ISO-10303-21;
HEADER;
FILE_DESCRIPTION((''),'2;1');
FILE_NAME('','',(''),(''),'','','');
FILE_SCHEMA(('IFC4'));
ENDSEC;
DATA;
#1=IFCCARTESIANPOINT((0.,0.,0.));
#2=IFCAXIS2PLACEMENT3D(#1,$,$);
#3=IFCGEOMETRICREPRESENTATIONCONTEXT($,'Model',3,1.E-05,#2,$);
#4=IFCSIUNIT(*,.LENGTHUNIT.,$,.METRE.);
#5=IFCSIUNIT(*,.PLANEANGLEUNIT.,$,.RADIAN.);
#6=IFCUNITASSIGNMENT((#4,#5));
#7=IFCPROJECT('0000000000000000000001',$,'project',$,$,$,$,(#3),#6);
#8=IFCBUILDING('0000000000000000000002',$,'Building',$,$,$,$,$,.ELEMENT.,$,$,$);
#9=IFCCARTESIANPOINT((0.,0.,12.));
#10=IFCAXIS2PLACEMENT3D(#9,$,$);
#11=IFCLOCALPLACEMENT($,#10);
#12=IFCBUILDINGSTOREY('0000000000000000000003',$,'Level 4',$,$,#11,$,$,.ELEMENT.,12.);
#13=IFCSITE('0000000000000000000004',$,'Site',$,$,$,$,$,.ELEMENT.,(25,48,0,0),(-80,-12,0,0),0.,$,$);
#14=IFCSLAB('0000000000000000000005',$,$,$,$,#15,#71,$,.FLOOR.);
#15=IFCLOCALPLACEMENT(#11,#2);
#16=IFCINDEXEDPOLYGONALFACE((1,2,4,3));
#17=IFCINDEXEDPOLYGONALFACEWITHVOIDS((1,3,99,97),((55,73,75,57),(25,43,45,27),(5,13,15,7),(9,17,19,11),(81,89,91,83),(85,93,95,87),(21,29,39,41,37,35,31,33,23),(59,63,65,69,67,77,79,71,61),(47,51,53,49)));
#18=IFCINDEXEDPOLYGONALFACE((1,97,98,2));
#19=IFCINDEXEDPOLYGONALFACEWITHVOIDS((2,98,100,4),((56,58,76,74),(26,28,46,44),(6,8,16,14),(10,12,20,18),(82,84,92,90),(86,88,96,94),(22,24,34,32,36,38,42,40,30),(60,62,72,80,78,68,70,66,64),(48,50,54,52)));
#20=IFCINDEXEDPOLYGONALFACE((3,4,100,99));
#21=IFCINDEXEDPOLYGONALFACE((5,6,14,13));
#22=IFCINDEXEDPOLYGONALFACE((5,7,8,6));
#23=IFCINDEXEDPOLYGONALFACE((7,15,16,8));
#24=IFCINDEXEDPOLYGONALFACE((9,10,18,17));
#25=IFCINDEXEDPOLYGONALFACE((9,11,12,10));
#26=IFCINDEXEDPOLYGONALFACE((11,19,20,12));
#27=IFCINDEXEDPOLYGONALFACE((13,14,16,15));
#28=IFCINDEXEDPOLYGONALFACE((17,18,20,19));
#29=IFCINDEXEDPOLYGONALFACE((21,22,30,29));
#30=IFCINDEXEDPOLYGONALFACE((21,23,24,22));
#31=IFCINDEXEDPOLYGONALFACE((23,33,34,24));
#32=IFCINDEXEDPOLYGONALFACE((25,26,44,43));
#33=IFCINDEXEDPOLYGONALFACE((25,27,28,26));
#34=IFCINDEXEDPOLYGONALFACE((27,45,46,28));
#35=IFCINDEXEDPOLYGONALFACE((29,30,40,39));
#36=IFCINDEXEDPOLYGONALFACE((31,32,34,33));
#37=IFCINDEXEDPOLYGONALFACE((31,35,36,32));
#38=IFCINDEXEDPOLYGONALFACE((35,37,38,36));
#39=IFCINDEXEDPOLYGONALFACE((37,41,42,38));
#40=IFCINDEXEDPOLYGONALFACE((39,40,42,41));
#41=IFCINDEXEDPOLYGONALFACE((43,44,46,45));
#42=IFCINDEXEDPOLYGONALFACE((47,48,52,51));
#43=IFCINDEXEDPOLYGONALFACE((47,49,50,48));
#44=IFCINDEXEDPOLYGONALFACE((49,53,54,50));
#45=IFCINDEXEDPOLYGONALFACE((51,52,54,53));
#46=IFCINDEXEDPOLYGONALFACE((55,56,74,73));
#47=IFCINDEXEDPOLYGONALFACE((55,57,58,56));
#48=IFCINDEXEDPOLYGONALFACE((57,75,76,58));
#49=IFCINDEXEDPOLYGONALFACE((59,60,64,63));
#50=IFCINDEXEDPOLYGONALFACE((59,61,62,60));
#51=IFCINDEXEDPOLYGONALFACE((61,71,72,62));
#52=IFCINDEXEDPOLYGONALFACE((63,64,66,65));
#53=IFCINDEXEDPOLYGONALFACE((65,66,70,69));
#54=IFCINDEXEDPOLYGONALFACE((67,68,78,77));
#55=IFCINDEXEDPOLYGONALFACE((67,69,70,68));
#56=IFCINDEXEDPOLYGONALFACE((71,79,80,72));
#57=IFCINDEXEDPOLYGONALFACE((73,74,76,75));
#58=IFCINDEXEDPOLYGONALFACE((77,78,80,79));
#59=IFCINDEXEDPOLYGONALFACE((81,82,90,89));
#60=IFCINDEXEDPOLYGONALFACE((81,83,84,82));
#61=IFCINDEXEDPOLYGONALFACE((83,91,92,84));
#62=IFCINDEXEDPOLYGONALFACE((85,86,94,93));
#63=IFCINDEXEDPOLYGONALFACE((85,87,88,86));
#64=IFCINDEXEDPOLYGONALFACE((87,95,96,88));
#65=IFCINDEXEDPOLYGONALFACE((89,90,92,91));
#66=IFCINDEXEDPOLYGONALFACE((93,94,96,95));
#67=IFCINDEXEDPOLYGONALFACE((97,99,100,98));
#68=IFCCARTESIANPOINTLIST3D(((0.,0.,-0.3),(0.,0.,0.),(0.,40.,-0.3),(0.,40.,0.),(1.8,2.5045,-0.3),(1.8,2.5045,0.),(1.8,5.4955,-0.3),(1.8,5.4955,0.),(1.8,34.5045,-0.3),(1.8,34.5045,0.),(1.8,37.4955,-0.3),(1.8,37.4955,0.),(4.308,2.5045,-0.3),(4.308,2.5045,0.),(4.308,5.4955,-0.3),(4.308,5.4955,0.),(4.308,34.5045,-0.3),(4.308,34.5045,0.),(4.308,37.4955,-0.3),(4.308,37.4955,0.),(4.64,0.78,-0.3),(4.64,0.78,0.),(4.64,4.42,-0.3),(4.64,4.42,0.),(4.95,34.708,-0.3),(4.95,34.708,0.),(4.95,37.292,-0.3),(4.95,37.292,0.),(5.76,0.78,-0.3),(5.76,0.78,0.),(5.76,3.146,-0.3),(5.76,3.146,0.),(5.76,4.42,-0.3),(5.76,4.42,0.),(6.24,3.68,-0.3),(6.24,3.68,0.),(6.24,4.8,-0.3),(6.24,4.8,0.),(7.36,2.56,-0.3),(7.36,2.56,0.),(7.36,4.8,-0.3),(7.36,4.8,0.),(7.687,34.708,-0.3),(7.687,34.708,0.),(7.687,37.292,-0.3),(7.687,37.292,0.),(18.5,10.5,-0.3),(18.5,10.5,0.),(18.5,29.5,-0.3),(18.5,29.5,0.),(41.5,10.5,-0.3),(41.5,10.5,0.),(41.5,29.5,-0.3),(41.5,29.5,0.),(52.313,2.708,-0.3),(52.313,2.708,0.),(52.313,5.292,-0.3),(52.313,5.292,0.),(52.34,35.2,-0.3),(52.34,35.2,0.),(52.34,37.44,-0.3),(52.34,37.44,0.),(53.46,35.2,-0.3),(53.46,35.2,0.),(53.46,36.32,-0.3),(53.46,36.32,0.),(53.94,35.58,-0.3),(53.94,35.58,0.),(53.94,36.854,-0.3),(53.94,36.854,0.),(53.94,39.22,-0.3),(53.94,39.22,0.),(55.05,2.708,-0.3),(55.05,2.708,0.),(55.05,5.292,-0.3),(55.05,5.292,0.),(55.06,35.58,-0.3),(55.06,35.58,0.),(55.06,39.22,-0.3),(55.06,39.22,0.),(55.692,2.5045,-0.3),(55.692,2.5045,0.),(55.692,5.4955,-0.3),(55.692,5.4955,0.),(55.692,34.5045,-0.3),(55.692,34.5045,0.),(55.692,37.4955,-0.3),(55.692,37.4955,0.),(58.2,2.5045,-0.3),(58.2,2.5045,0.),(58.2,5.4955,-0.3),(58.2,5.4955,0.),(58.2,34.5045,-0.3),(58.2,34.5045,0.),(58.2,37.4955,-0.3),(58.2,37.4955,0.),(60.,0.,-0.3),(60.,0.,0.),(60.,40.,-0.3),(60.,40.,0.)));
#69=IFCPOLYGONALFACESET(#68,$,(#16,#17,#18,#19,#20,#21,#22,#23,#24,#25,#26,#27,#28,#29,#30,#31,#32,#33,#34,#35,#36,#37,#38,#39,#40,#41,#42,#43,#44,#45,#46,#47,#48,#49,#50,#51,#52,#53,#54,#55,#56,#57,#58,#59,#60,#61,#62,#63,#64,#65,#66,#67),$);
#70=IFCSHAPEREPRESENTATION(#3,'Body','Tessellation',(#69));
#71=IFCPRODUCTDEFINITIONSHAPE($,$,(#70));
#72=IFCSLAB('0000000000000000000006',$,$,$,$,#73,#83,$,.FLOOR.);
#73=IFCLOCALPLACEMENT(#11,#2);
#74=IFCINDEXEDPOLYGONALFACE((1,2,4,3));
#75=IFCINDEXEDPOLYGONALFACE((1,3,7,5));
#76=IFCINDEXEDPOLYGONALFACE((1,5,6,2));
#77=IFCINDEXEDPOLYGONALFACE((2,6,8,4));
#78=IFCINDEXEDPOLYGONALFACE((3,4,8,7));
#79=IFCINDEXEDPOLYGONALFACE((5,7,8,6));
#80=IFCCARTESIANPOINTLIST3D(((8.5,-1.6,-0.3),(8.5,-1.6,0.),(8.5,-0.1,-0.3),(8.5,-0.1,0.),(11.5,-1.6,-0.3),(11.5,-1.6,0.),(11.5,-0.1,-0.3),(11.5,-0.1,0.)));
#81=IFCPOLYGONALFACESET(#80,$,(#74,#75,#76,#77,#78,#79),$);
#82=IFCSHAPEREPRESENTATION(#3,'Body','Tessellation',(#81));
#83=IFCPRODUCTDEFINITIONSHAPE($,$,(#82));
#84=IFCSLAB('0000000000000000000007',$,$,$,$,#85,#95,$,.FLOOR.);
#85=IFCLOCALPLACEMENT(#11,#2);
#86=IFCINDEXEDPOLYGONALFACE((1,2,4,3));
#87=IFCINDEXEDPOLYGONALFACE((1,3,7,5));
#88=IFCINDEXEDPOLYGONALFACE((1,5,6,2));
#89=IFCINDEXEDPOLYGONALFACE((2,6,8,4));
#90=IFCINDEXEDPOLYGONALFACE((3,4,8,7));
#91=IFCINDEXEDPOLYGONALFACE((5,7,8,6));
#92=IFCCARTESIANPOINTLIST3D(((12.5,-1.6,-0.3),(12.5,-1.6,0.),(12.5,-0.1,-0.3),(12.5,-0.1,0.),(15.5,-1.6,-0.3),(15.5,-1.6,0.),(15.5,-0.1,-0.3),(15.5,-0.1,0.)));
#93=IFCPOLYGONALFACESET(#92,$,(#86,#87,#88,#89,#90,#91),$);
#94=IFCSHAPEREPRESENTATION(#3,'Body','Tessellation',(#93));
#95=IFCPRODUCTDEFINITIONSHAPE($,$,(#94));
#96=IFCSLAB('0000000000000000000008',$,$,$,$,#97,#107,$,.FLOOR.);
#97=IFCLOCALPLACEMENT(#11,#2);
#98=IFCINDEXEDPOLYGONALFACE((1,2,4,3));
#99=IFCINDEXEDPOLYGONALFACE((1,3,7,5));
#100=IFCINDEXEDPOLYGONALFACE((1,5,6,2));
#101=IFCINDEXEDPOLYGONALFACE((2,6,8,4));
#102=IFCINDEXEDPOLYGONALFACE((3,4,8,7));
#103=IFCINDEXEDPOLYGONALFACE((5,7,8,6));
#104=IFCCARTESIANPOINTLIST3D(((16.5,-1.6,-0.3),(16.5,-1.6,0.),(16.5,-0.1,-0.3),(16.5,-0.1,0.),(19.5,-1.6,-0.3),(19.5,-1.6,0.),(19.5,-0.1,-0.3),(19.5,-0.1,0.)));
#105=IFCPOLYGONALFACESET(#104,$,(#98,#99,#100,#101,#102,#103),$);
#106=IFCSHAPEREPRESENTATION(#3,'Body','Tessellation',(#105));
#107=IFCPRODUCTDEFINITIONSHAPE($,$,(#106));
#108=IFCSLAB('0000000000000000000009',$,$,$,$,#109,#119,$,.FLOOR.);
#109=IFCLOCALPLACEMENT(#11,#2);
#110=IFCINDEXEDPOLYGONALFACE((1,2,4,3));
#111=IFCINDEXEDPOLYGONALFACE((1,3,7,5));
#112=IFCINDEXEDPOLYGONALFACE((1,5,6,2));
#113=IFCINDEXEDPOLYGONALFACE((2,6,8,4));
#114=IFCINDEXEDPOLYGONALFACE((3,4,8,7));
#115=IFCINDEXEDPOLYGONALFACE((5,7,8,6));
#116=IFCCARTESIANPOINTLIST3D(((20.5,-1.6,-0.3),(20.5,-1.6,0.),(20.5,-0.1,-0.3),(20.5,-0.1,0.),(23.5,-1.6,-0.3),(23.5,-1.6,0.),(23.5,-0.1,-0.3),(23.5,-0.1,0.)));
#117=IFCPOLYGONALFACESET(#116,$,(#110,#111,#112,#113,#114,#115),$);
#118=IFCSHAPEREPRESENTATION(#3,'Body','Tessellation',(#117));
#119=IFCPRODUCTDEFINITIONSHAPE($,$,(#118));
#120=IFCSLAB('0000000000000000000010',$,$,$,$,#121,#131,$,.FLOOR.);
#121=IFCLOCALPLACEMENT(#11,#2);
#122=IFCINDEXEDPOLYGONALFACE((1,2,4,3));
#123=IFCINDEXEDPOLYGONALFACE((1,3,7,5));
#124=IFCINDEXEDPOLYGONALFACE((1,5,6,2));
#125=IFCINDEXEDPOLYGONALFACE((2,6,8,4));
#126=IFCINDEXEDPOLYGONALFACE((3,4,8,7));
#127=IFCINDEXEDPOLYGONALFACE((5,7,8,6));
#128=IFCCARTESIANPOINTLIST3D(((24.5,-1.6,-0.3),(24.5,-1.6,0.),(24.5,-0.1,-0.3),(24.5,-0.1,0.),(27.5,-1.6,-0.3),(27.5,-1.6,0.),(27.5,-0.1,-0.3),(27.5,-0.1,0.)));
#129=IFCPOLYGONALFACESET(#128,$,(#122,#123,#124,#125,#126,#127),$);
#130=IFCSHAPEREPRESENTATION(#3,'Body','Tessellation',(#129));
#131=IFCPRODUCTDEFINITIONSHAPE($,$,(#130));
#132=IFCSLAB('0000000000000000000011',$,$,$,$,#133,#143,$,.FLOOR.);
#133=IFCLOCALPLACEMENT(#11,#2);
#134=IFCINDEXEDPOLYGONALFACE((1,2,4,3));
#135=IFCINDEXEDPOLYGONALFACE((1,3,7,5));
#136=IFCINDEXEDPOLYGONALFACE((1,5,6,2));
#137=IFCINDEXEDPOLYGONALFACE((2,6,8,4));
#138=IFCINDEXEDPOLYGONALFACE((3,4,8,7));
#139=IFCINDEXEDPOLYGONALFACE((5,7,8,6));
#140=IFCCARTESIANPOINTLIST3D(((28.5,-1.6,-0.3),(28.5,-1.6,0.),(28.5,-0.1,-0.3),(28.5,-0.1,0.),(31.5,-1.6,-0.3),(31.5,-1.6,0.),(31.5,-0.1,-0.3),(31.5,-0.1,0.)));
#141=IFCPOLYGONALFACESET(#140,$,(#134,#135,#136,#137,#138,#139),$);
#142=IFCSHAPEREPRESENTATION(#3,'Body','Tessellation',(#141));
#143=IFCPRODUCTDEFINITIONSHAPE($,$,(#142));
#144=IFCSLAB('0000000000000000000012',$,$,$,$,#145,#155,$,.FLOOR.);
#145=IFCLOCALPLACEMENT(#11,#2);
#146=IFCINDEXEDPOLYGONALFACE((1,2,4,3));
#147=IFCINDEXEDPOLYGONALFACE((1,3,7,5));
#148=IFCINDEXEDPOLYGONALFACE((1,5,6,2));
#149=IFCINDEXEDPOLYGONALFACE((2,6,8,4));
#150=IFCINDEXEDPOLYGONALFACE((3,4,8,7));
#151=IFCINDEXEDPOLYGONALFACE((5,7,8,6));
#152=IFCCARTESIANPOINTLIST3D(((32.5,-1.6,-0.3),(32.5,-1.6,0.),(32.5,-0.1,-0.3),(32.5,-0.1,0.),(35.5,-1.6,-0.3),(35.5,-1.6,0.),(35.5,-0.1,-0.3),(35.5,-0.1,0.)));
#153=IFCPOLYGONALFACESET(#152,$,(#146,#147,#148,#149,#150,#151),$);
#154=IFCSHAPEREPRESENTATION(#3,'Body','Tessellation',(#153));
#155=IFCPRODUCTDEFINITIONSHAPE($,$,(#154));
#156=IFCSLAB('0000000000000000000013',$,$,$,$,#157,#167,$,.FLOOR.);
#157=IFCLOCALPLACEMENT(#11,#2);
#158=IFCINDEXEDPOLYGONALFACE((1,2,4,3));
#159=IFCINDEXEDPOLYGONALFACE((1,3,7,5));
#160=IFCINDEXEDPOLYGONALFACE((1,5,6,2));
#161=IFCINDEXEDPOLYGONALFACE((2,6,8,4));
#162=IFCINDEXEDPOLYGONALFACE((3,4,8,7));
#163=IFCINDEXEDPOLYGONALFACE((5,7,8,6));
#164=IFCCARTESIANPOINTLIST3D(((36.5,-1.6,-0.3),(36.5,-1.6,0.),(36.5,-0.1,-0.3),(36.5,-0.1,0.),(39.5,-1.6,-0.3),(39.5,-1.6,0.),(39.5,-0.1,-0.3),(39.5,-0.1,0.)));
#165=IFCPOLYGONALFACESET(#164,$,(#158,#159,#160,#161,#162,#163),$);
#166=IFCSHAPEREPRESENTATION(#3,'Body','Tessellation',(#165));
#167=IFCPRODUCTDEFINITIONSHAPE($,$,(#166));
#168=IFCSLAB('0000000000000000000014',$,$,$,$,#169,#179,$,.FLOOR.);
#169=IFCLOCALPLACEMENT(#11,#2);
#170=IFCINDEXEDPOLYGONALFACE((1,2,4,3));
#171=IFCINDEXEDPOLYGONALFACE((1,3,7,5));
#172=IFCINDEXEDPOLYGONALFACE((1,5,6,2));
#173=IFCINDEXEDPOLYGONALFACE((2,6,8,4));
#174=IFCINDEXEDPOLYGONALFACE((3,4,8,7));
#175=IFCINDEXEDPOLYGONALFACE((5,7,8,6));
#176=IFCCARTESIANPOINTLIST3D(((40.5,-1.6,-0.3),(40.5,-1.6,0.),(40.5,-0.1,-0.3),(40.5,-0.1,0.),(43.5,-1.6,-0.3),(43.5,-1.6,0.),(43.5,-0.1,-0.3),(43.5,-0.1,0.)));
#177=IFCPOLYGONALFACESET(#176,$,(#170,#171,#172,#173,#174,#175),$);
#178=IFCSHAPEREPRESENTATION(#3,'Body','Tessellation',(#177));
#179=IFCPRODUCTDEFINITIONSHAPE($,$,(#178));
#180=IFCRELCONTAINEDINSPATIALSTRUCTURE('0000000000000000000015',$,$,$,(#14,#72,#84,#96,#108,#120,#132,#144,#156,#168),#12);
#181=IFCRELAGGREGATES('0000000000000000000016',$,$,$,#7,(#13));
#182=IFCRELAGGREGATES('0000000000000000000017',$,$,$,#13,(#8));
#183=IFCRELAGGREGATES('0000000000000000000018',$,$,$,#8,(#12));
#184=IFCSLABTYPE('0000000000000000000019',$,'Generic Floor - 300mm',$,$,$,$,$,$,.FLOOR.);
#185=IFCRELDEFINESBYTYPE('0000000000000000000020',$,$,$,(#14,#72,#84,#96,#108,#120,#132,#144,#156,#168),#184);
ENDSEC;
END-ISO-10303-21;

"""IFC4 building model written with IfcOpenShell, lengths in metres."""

from ifc_helpers import new_model, si_unit, frame, origin, place, context, project, spatial, polyline, outline, extrude, type_object, element, save


model = new_model("IFC4")

# Units and contexts
model_context = context("Model", 3, precision=1e-05, world=origin())
ifc_project = project(units=[si_unit("LENGTHUNIT", "METRE"), si_unit("PLANEANGLEUNIT", "RADIAN")], contexts=[model_context])

# Site, building, storey
site = spatial("IfcSite", under=ifc_project, Name="Site", CompositionType="ELEMENT", RefLatitude=(25, 48, 0, 0), RefLongitude=(-80, -12, 0, 0), RefElevation=0.0)
building = spatial("IfcBuilding", under=site, Name="Building", CompositionType="ELEMENT")
storey_placement = place(None, frame((0.0, 0.0, 12.0)))
storey = spatial("IfcBuildingStorey", under=building, at=storey_placement, Name="Level 4", CompositionType="ELEMENT", Elevation=12.0)

# Slab, openings
slab_type = type_object("IfcSlabType", Name="Generic Floor - 300mm", PredefinedType="FLOOR")
slab_1_placement = place(None, frame((0.0, 0.0, 12.0)))
slab_1 = element("IfcSlab", 1, at=slab_1_placement, inside=storey, type_object=slab_type, PredefinedType="FLOOR", context=model_context, shape_type="SweptSolid", body=[
    extrude(outline(polyline([(0.0, 0.0), (60.0, 0.0), (60.0, 40.0), (0.0, 40.0), (0.0, 0.0)])), origin(), (0.0, 0.0, -1.0), 0.3),
])
opening_1_placement = place(None, frame((0.0, 0.0, 12.001)))
element("IfcOpeningElement", 2, at=opening_1_placement, cuts=slab_1, PredefinedType="OPENING", context=model_context, shape_type="SweptSolid", body=[
    extrude(outline(polyline([(4.64, 0.78), (5.76, 0.78), (7.36, 2.56), (7.36, 4.8), (6.24, 4.8), (6.24, 3.68), (5.76, 3.146), (5.76, 4.42), (4.64, 4.42), (4.64, 0.78)])), origin(), (0.0, 0.0, -1.0), 0.302),
])
opening_2_placement = place(None, frame((0.0, 0.0, 12.001)))
element("IfcOpeningElement", 3, at=opening_2_placement, cuts=slab_1, PredefinedType="OPENING", context=model_context, shape_type="SweptSolid", body=[
    extrude(outline(polyline([(52.34, 35.2), (53.46, 35.2), (53.46, 36.32), (53.94, 36.854), (53.94, 35.58), (55.06, 35.58), (55.06, 39.22), (53.94, 39.22), (52.34, 37.44), (52.34, 35.2)])), origin(), (0.0, 0.0, -1.0), 0.302),
])
opening_3_placement = place(None, frame((0.0, 0.0, 12.001)))
element("IfcOpeningElement", 4, at=opening_3_placement, cuts=slab_1, PredefinedType="OPENING", context=model_context, shape_type="SweptSolid", body=[
    extrude(outline(polyline([(1.8, 5.4955), (1.8, 2.5045), (4.308, 2.5045), (4.308, 5.4955), (1.8, 5.4955)])), origin(), (0.0, 0.0, -1.0), 0.302),
])
opening_4_placement = place(None, frame((0.0, 0.0, 12.001)))
element("IfcOpeningElement", 5, at=opening_4_placement, cuts=slab_1, PredefinedType="OPENING", context=model_context, shape_type="SweptSolid", body=[
    extrude(outline(polyline([(58.2, 2.5045), (58.2, 5.4955), (55.692, 5.4955), (55.692, 2.5045), (58.2, 2.5045)])), origin(), (0.0, 0.0, -1.0), 0.302),
])
opening_5_placement = place(None, frame((0.0, 0.0, 12.001)))
element("IfcOpeningElement", 6, at=opening_5_placement, cuts=slab_1, PredefinedType="OPENING", context=model_context, shape_type="SweptSolid", body=[
    extrude(outline(polyline([(55.05, 2.708), (55.05, 5.292), (52.313, 5.292), (52.313, 2.708), (55.05, 2.708)])), origin(), (0.0, 0.0, -1.0), 0.302),
])
opening_6_placement = place(None, frame((0.0, 0.0, 12.001)))
element("IfcOpeningElement", 7, at=opening_6_placement, cuts=slab_1, PredefinedType="OPENING", context=model_context, shape_type="SweptSolid", body=[
    extrude(outline(polyline([(1.8, 37.4955), (1.8, 34.5045), (4.308, 34.5045), (4.308, 37.4955), (1.8, 37.4955)])), origin(), (0.0, 0.0, -1.0), 0.302),
])
opening_7_placement = place(None, frame((0.0, 0.0, 12.001)))
element("IfcOpeningElement", 8, at=opening_7_placement, cuts=slab_1, PredefinedType="OPENING", context=model_context, shape_type="SweptSolid", body=[
    extrude(outline(polyline([(4.95, 37.292), (4.95, 34.708), (7.687, 34.708), (7.687, 37.292), (4.95, 37.292)])), origin(), (0.0, 0.0, -1.0), 0.302),
])
opening_8_placement = place(None, frame((0.0, 0.0, 12.001)))
element("IfcOpeningElement", 9, at=opening_8_placement, cuts=slab_1, PredefinedType="OPENING", context=model_context, shape_type="SweptSolid", body=[
    extrude(outline(polyline([(58.2, 34.5045), (58.2, 37.4955), (55.692, 37.4955), (55.692, 34.5045), (58.2, 34.5045)])), origin(), (0.0, 0.0, -1.0), 0.302),
])
opening_9_placement = place(None, frame((0.0, 0.0, 12.001)))
element("IfcOpeningElement", 10, at=opening_9_placement, cuts=slab_1, PredefinedType="OPENING", context=model_context, shape_type="SweptSolid", body=[
    extrude(outline(polyline([(18.5, 10.5), (41.5, 10.5), (41.5, 29.5), (18.5, 29.5), (18.5, 10.5)])), origin(), (0.0, 0.0, -1.0), 0.302),
])

# Slabs
slab_2_placement = place(None, frame((0.0, 0.0, 12.0)))
element("IfcSlab", 11, at=slab_2_placement, inside=storey, type_object=slab_type, PredefinedType="FLOOR", context=model_context, shape_type="SweptSolid", body=[
    extrude(outline(polyline([(11.5, -0.1), (8.5, -0.1), (8.5, -1.6), (11.5, -1.6), (11.5, -0.1)])), origin(), (0.0, 0.0, -1.0), 0.3),
])
slab_3_placement = place(None, frame((0.0, 0.0, 12.0)))
element("IfcSlab", 12, at=slab_3_placement, inside=storey, type_object=slab_type, PredefinedType="FLOOR", context=model_context, shape_type="SweptSolid", body=[
    extrude(outline(polyline([(12.5, -0.1), (12.5, -1.6), (15.5, -1.6), (15.5, -0.1), (12.5, -0.1)])), origin(), (0.0, 0.0, -1.0), 0.3),
])
slab_4_placement = place(None, frame((0.0, 0.0, 12.0)))
element("IfcSlab", 13, at=slab_4_placement, inside=storey, type_object=slab_type, PredefinedType="FLOOR", context=model_context, shape_type="SweptSolid", body=[
    extrude(outline(polyline([(19.5, -0.1), (16.5, -0.1), (16.5, -1.6), (19.5, -1.6), (19.5, -0.1)])), origin(), (0.0, 0.0, -1.0), 0.3),
])
slab_5_placement = place(None, frame((0.0, 0.0, 12.0)))
element("IfcSlab", 14, at=slab_5_placement, inside=storey, type_object=slab_type, PredefinedType="FLOOR", context=model_context, shape_type="SweptSolid", body=[
    extrude(outline(polyline([(20.5, -0.1), (20.5, -1.6), (23.5, -1.6), (23.5, -0.1), (20.5, -0.1)])), origin(), (0.0, 0.0, -1.0), 0.3),
])
slab_6_placement = place(None, frame((0.0, 0.0, 12.0)))
element("IfcSlab", 15, at=slab_6_placement, inside=storey, type_object=slab_type, PredefinedType="FLOOR", context=model_context, shape_type="SweptSolid", body=[
    extrude(outline(polyline([(27.5, -0.1), (24.5, -0.1), (24.5, -1.6), (27.5, -1.6), (27.5, -0.1)])), origin(), (0.0, 0.0, -1.0), 0.3),
])
slab_7_placement = place(None, frame((0.0, 0.0, 12.0)))
element("IfcSlab", 16, at=slab_7_placement, inside=storey, type_object=slab_type, PredefinedType="FLOOR", context=model_context, shape_type="SweptSolid", body=[
    extrude(outline(polyline([(28.5, -0.1), (28.5, -1.6), (31.5, -1.6), (31.5, -0.1), (28.5, -0.1)])), origin(), (0.0, 0.0, -1.0), 0.3),
])
slab_8_placement = place(None, frame((0.0, 0.0, 12.0)))
element("IfcSlab", 17, at=slab_8_placement, inside=storey, type_object=slab_type, PredefinedType="FLOOR", context=model_context, shape_type="SweptSolid", body=[
    extrude(outline(polyline([(35.5, -0.1), (32.5, -0.1), (32.5, -1.6), (35.5, -1.6), (35.5, -0.1)])), origin(), (0.0, 0.0, -1.0), 0.3),
])
slab_9_placement = place(None, frame((0.0, 0.0, 12.0)))
element("IfcSlab", 18, at=slab_9_placement, inside=storey, type_object=slab_type, PredefinedType="FLOOR", context=model_context, shape_type="SweptSolid", body=[
    extrude(outline(polyline([(36.5, -0.1), (36.5, -1.6), (39.5, -1.6), (39.5, -0.1), (36.5, -0.1)])), origin(), (0.0, 0.0, -1.0), 0.3),
])
slab_10_placement = place(None, frame((0.0, 0.0, 12.0)))
element("IfcSlab", 19, at=slab_10_placement, inside=storey, type_object=slab_type, PredefinedType="FLOOR", context=model_context, shape_type="SweptSolid", body=[
    extrude(outline(polyline([(43.5, -0.1), (40.5, -0.1), (40.5, -1.6), (43.5, -1.6), (43.5, -0.1)])), origin(), (0.0, 0.0, -1.0), 0.3),
])

save(model, "model.ifc")
